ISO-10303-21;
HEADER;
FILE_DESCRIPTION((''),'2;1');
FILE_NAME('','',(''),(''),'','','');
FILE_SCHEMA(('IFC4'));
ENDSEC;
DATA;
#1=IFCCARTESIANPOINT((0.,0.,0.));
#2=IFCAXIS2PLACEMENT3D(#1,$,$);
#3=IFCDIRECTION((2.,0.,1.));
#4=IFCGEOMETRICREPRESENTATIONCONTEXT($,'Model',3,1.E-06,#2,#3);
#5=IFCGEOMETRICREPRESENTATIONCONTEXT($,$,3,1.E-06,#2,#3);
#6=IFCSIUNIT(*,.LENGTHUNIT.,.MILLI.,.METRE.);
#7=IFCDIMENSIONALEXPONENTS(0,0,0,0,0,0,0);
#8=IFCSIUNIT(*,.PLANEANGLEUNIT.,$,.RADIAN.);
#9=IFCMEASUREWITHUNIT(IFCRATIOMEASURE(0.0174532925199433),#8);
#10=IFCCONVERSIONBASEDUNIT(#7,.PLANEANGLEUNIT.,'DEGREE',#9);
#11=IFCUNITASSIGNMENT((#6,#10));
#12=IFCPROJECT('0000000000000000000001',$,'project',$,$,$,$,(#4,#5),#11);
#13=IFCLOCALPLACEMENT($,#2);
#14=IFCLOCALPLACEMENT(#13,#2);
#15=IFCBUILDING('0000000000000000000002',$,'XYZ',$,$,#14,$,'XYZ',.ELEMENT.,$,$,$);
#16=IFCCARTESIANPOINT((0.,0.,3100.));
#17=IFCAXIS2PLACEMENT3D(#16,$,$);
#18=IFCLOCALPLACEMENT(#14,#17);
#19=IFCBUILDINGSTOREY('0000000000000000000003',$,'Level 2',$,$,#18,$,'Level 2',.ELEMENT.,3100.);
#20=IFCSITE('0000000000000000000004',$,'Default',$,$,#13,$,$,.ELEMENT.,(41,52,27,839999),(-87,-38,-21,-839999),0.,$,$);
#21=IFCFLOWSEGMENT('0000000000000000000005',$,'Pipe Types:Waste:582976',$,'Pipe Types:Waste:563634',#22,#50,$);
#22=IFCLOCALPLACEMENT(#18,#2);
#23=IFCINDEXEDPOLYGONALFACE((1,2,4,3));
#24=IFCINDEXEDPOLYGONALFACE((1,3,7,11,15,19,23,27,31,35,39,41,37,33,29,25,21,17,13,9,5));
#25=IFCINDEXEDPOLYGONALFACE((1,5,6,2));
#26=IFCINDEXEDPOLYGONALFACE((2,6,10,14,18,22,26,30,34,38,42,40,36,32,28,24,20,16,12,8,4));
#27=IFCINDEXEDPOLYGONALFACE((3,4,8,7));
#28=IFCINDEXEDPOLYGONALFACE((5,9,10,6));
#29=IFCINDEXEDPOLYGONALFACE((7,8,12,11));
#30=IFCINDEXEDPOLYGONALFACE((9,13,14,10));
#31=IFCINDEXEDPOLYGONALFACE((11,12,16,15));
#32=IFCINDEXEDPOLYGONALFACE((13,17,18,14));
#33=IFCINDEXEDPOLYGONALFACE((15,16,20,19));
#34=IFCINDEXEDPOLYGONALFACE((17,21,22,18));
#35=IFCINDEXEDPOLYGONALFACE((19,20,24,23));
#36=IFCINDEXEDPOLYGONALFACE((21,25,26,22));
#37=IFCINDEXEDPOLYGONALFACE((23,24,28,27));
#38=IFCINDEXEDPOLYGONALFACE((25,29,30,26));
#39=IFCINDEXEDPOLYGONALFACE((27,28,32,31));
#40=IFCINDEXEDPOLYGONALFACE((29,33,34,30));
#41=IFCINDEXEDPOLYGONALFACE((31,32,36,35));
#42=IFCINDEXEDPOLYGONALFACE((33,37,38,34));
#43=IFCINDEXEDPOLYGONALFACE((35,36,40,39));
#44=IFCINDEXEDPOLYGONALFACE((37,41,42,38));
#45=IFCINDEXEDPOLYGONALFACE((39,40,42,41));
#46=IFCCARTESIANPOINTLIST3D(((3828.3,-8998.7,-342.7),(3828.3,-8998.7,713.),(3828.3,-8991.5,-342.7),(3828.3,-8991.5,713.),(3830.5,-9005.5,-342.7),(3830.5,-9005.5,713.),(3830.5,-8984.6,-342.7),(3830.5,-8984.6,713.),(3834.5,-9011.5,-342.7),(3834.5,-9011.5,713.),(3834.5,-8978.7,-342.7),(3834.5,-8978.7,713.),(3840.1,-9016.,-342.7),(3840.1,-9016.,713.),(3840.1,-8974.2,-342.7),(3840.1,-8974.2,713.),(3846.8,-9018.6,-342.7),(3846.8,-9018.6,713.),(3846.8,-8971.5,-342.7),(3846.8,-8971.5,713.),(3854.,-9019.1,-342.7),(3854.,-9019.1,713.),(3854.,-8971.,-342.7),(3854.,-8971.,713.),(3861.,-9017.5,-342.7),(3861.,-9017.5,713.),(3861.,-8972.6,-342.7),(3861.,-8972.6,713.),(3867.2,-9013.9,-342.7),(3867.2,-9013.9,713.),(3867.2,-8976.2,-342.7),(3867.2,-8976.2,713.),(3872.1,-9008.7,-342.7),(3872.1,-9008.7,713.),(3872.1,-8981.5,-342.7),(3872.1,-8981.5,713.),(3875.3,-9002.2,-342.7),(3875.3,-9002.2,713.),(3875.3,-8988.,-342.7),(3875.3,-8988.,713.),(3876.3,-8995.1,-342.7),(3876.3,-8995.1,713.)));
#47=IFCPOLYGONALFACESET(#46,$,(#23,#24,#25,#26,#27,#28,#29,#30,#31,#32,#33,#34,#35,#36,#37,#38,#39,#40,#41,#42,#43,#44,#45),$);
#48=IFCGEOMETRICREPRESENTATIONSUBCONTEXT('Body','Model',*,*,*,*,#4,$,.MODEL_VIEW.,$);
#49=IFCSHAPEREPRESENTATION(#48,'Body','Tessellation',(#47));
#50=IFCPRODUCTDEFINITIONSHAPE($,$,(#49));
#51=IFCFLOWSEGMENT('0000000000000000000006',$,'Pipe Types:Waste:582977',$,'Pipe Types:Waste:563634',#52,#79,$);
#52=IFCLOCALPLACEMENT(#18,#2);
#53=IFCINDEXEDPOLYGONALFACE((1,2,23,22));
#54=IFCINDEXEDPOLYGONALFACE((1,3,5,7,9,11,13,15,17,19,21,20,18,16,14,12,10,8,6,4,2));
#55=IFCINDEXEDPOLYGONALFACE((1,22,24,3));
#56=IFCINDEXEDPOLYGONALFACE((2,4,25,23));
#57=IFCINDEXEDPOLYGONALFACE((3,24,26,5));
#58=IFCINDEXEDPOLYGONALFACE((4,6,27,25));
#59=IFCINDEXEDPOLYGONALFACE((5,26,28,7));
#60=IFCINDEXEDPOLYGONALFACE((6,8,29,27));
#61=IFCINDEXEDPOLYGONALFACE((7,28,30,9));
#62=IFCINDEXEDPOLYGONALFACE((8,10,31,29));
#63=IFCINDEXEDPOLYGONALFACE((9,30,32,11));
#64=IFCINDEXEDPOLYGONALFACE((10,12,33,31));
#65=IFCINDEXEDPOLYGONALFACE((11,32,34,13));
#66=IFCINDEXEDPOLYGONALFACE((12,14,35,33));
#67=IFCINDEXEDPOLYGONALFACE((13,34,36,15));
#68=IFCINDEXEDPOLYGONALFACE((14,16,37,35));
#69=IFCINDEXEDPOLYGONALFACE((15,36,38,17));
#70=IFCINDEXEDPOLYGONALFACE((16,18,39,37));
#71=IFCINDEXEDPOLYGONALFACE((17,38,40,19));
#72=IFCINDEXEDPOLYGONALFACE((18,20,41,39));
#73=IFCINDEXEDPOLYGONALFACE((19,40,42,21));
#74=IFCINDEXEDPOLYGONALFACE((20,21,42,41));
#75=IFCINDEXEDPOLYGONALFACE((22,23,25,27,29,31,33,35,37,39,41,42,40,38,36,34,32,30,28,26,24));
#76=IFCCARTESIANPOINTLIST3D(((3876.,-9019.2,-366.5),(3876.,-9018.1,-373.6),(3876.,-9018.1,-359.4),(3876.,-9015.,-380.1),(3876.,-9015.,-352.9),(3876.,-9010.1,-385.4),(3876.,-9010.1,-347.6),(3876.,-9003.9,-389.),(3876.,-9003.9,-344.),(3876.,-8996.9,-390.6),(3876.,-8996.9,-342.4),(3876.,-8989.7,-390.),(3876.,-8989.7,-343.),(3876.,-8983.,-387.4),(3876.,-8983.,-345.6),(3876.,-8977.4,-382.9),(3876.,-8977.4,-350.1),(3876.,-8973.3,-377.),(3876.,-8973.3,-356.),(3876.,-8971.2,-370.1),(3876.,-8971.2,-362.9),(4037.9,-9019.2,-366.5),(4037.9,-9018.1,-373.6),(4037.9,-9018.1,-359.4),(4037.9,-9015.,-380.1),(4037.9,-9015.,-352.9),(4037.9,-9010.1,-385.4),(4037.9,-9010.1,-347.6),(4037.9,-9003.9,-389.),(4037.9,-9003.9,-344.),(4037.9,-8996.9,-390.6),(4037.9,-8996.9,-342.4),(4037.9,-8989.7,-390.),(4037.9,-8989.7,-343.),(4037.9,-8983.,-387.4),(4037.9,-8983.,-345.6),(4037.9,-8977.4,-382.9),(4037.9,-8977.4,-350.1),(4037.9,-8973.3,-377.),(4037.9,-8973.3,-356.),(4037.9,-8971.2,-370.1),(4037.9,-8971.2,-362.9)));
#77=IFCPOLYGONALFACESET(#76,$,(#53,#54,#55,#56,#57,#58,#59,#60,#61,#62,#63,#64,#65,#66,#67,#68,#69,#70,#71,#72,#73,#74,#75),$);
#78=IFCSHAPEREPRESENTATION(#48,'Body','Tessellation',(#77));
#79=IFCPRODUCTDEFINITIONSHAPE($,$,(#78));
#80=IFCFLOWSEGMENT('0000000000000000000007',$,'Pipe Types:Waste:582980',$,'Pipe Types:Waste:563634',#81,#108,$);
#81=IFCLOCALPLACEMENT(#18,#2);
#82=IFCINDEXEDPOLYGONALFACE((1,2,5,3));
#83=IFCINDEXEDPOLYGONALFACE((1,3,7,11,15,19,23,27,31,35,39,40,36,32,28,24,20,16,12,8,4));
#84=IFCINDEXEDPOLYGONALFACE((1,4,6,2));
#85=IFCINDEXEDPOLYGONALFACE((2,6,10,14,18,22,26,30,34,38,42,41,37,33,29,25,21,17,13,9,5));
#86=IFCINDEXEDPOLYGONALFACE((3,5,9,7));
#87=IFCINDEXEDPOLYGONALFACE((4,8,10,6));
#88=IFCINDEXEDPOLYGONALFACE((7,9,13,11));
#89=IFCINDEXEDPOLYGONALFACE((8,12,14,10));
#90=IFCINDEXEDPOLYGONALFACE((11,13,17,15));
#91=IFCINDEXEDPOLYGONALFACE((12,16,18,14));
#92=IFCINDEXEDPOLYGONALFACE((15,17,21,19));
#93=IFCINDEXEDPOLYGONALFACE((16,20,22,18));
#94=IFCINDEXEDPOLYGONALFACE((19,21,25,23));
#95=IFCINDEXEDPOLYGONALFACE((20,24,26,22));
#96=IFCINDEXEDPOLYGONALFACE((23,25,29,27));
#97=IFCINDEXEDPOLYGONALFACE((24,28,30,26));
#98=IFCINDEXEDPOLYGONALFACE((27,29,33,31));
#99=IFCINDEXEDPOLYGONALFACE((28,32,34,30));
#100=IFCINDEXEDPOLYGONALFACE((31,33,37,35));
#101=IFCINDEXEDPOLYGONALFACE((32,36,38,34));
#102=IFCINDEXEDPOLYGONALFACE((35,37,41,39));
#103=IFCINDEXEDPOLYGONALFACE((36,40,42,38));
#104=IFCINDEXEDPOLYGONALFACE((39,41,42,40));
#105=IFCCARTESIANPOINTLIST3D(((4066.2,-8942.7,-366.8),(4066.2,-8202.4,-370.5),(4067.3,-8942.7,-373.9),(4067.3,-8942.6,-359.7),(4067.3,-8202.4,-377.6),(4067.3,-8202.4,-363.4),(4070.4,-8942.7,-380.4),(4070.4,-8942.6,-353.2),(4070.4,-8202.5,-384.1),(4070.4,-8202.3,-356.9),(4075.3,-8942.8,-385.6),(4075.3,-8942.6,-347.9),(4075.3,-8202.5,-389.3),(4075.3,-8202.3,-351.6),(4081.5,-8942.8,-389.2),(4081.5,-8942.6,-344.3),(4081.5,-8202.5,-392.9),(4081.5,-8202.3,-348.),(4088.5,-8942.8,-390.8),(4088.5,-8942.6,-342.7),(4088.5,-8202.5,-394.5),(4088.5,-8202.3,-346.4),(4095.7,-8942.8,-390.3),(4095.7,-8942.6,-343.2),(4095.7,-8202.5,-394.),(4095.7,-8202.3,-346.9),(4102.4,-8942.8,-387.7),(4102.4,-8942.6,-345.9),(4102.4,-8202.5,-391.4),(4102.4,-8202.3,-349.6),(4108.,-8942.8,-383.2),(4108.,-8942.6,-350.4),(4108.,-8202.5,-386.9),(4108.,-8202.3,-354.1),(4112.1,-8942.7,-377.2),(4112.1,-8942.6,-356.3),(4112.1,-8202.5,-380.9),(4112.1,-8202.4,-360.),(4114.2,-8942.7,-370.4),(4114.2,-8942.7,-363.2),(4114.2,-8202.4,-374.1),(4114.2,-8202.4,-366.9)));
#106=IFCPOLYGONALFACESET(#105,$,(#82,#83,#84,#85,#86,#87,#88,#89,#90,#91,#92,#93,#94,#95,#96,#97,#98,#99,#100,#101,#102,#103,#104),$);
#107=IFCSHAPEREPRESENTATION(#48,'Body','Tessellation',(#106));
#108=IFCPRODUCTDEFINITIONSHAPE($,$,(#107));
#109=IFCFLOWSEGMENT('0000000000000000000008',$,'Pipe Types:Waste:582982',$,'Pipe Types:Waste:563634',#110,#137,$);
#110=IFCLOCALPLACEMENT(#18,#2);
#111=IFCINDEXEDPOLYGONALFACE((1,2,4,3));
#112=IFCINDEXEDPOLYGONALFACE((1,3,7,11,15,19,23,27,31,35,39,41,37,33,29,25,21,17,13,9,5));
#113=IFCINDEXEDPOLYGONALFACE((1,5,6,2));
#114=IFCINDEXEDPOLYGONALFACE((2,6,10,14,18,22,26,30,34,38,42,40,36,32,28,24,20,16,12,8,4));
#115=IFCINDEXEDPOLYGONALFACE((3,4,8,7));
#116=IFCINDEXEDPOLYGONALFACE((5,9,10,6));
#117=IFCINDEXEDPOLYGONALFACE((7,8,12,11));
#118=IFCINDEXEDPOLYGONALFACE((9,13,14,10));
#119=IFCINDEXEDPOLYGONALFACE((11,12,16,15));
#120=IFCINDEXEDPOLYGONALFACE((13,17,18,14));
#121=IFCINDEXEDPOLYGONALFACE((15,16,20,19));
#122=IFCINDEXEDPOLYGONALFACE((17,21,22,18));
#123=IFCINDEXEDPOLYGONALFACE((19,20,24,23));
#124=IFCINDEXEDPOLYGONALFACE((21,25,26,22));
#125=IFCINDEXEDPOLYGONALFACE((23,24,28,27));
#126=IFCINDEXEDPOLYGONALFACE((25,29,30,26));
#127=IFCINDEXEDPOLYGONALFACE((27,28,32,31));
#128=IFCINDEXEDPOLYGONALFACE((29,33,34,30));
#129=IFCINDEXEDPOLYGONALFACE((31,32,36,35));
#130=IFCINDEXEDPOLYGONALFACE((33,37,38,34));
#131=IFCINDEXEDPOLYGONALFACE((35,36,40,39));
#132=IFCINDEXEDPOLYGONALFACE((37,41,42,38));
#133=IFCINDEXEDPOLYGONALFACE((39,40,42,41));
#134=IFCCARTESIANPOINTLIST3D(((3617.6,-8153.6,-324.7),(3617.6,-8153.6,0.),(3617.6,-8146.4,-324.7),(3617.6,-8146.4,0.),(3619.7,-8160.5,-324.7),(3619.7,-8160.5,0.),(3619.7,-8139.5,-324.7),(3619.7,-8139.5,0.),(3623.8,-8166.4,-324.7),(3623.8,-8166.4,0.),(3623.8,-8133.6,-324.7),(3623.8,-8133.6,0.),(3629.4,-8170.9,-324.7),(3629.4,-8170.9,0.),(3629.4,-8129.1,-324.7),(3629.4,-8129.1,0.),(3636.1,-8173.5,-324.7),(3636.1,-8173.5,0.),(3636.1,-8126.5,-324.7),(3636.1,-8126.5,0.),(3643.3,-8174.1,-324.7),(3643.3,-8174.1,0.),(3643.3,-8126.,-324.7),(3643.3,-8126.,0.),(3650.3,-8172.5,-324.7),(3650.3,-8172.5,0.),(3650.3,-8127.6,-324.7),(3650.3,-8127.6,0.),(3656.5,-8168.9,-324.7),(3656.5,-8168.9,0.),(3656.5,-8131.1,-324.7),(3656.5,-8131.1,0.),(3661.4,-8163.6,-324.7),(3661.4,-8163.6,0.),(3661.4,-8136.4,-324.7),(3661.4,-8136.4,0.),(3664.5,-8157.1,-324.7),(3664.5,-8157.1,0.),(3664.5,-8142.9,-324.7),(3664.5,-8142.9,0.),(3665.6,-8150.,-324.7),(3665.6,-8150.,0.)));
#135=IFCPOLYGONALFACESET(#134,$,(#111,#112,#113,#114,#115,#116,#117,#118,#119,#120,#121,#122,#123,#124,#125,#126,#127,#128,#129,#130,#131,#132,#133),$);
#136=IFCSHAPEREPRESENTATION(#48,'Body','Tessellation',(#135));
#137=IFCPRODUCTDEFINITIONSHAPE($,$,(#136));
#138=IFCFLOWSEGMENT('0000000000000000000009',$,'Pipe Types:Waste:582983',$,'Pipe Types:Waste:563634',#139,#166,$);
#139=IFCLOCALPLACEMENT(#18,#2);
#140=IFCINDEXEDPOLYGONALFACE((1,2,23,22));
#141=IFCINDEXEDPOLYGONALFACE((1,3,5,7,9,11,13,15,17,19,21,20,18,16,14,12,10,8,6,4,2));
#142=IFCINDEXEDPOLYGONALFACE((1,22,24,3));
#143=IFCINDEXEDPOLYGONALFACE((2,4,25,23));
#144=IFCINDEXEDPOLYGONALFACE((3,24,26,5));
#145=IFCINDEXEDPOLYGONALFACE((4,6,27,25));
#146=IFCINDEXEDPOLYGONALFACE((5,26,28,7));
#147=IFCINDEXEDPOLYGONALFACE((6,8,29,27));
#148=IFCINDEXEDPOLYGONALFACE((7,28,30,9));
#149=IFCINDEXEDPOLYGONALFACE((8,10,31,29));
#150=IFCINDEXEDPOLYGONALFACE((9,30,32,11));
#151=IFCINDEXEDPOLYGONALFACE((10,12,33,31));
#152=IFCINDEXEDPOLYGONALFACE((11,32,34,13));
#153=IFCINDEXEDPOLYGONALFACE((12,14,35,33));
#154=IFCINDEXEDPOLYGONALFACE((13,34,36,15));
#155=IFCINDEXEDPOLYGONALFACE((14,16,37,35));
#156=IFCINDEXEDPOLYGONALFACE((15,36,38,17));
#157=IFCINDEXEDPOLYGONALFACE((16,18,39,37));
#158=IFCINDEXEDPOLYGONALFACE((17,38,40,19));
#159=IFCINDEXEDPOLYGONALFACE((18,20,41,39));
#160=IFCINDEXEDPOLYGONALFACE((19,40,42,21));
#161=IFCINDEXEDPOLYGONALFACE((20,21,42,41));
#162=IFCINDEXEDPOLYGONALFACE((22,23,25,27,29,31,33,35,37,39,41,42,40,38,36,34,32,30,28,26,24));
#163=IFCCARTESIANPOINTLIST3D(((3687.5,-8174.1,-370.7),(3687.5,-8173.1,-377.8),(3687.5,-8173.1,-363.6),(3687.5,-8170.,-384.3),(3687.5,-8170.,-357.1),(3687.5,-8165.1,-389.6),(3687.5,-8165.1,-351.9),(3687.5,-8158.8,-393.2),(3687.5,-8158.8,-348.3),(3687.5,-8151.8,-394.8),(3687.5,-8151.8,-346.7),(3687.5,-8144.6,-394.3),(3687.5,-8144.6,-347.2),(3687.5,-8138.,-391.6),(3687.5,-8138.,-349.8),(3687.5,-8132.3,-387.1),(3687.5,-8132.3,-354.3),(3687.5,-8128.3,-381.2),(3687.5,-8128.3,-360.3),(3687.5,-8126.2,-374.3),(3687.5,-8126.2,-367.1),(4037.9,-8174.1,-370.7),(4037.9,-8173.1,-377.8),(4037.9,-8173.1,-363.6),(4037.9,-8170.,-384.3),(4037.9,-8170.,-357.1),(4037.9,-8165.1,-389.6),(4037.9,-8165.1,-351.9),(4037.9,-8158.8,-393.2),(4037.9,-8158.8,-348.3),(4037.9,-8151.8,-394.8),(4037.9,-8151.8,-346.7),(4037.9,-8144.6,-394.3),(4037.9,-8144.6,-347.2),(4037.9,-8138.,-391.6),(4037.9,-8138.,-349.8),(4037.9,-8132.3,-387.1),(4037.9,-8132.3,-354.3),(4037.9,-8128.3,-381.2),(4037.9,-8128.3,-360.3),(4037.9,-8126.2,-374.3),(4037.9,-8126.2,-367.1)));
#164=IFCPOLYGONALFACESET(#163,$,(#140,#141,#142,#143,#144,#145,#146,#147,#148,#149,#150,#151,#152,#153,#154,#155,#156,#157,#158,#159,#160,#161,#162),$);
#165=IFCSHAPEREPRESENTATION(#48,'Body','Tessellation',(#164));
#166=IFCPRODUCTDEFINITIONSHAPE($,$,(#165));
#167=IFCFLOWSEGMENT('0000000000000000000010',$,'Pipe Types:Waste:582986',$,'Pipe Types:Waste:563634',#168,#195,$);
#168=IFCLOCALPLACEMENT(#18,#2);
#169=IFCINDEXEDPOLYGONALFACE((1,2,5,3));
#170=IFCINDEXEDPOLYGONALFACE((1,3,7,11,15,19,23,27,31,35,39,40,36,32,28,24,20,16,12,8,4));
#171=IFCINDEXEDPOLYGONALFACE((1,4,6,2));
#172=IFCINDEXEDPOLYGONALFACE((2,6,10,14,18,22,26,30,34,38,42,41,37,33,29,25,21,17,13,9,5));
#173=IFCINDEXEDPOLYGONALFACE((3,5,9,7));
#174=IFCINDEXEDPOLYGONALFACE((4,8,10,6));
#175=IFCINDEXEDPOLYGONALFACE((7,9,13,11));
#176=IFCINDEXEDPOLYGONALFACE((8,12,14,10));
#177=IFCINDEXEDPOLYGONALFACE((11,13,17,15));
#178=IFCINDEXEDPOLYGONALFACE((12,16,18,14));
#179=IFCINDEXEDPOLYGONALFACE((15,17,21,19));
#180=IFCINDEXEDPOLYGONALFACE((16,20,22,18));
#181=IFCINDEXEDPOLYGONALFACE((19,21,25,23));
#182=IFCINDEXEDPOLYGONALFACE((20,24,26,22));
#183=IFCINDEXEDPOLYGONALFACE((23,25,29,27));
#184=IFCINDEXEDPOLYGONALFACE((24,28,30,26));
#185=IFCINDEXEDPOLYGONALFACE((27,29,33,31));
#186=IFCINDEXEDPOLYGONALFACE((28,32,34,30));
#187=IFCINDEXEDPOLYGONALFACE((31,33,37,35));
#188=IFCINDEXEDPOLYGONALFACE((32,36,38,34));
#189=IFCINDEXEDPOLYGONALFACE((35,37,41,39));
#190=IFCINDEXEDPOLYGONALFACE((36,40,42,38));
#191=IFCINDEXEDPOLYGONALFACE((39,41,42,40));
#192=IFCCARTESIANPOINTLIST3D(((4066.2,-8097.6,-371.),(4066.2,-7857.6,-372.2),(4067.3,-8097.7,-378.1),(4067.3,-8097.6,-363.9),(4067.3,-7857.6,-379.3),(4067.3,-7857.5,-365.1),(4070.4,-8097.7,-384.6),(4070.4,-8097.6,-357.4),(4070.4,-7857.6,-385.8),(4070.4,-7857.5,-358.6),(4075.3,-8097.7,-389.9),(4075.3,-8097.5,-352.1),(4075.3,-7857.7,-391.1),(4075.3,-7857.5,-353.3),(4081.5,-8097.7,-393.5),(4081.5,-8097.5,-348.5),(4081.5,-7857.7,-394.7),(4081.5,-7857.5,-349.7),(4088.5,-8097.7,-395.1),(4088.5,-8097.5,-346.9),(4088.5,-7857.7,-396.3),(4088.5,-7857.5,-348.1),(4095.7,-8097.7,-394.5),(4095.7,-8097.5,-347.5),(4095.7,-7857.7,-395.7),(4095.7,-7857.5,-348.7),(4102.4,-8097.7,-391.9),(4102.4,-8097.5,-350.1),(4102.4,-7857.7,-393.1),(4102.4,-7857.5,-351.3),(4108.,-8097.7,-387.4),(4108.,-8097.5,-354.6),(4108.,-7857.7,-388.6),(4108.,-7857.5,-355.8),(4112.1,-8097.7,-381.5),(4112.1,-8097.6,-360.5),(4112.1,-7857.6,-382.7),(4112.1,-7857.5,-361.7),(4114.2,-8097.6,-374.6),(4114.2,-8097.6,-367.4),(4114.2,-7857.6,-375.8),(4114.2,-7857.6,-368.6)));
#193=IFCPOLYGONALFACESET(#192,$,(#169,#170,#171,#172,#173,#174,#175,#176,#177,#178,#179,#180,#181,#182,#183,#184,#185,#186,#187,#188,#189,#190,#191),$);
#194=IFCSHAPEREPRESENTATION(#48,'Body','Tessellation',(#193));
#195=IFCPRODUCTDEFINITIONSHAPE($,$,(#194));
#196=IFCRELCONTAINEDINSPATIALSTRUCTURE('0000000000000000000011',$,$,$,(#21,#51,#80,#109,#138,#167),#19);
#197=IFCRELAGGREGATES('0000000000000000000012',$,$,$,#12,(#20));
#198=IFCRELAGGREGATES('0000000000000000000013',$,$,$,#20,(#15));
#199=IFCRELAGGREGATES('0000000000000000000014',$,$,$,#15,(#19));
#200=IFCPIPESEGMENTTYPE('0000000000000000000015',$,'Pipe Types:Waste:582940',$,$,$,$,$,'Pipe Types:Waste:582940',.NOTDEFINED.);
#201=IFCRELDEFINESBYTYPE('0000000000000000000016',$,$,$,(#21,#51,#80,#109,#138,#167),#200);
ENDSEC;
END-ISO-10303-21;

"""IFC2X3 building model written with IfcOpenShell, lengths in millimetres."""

from ifc_helpers import new_model, entity, si_unit, converted_unit, direction, frame, frame_2d, origin, origin_2d_with_axis, place, context, subcontext, project, spatial, circle, extrude, type_object, element, save


model = new_model("IFC2X3")

# Units and contexts
model_context = context("Model", 3, precision=1e-06, world=origin(), true_north=direction((2.0, 0.0, 1.0)))
context_of_model = context(None, 3, precision=1e-06, world=origin(), true_north=direction((2.0, 0.0, 1.0)))
body_context = subcontext(model_context, "Body", "Model", "MODEL_VIEW")
ifc_project = project(units=[si_unit("LENGTHUNIT", "METRE", prefix="MILLI"), converted_unit("PLANEANGLEUNIT", "DEGREE", entity("IfcRatioMeasure", 0.0174532925199433), si_unit("PLANEANGLEUNIT", "RADIAN"), dimensions=[0, 0, 0, 0, 0, 0, 0])], contexts=[model_context, context_of_model])

# Site, building, storey
site_placement = place(None, origin())
site = spatial("IfcSite", under=ifc_project, at=site_placement, Name="Default", CompositionType="ELEMENT", RefLatitude=(41, 52, 27, 839999), RefLongitude=(-87, -38, -21, -839999), RefElevation=0.0)
building_placement = place(site_placement, origin())
building = spatial("IfcBuilding", under=site, at=building_placement, Name="XYZ", LongName="XYZ", CompositionType="ELEMENT")
storey_placement = place(building_placement, frame((0.0, 0.0, 3100.0)))
storey = spatial("IfcBuildingStorey", under=building, at=storey_placement, Name="Level 2", LongName="Level 2", CompositionType="ELEMENT", Elevation=3100.0)

# Flow segments
pipe_segment_type_1 = type_object("IfcPipeSegmentType", Name="Pipe Types:Waste:582940", ElementType="Pipe Types:Waste:582940", PredefinedType="NOTDEFINED")
flow_segment_1_placement = place(storey_placement, origin())
element("IfcFlowSegment", 1, at=flow_segment_1_placement, inside=storey, type_object=pipe_segment_type_1, Name="Pipe Types:Waste:582976", ObjectType="Pipe Types:Waste:563634", context=body_context, shape_type="SweptSolid", body=[
    extrude(circle(Radius=24.1, at=frame_2d((0.0, 0.0), x_axis=(1.0, 0.0))), frame((3852.2, -8995.1, -342.7)), (0.0, 0.0, 1.0), 1055.7),
])
flow_segment_2_placement = place(storey_placement, origin())
element("IfcFlowSegment", 2, at=flow_segment_2_placement, inside=storey, type_object=pipe_segment_type_1, Name="Pipe Types:Waste:582977", ObjectType="Pipe Types:Waste:563634", context=body_context, shape_type="SweptSolid", body=[
    extrude(circle(Radius=24.1, at=origin_2d_with_axis()), frame((3876.0, -8995.1, -366.5), z_axis=(1.0, 0.0, 0.0), x_axis=(0.0, -1.0, 0.0)), (0.0, 0.0, 1.0), 161.9),
])
flow_segment_3_placement = place(storey_placement, origin())
element("IfcFlowSegment", 3, at=flow_segment_3_placement, inside=storey, type_object=pipe_segment_type_1, Name="Pipe Types:Waste:582980", ObjectType="Pipe Types:Waste:563634", context=body_context, shape_type="SweptSolid", body=[
    extrude(circle(Radius=24.1, at=frame_2d((0.0, 0.0), x_axis=(1.0, 0.0))), frame((4090.3, -8942.7, -366.8), z_axis=(0.0, 0.999988, -0.005), x_axis=(-1.0, 0.0, 0.0)), (0.0, 0.0, 1.0), 740.3),
])
flow_segment_4_placement = place(storey_placement, origin())
element("IfcFlowSegment", 4, at=flow_segment_4_placement, inside=storey, type_object=pipe_segment_type_1, Name="Pipe Types:Waste:582982", ObjectType="Pipe Types:Waste:563634", context=body_context, shape_type="SweptSolid", body=[
    extrude(circle(Radius=24.1, at=origin_2d_with_axis()), frame((3641.5, -8150.0, -324.7)), (0.0, 0.0, 1.0), 324.7),
])
flow_segment_5_placement = place(storey_placement, origin())
element("IfcFlowSegment", 5, at=flow_segment_5_placement, inside=storey, type_object=pipe_segment_type_1, Name="Pipe Types:Waste:582983", ObjectType="Pipe Types:Waste:563634", context=body_context, shape_type="SweptSolid", body=[
    extrude(circle(Radius=24.1, at=frame_2d((0.0, 0.0), x_axis=(1.0, 0.0))), frame((3687.5, -8150.0, -370.7), z_axis=(1.0, 0.0, 0.0), x_axis=(0.0, -1.0, 0.0)), (0.0, 0.0, 1.0), 350.4),
])
flow_segment_6_placement = place(storey_placement, origin())
element("IfcFlowSegment", 6, at=flow_segment_6_placement, inside=storey, type_object=pipe_segment_type_1, Name="Pipe Types:Waste:582986", ObjectType="Pipe Types:Waste:563634", context=body_context, shape_type="SweptSolid", body=[
    extrude(circle(Radius=24.1, at=frame_2d((0.0, 0.0), x_axis=(1.0, 0.0))), frame((4090.3, -8097.6, -371.0), z_axis=(0.0, 0.999988, -0.005), x_axis=(-1.0, 0.0, 0.0)), (0.0, 0.0, 1.0), 240.1),
])

save(model, "model.ifc")
